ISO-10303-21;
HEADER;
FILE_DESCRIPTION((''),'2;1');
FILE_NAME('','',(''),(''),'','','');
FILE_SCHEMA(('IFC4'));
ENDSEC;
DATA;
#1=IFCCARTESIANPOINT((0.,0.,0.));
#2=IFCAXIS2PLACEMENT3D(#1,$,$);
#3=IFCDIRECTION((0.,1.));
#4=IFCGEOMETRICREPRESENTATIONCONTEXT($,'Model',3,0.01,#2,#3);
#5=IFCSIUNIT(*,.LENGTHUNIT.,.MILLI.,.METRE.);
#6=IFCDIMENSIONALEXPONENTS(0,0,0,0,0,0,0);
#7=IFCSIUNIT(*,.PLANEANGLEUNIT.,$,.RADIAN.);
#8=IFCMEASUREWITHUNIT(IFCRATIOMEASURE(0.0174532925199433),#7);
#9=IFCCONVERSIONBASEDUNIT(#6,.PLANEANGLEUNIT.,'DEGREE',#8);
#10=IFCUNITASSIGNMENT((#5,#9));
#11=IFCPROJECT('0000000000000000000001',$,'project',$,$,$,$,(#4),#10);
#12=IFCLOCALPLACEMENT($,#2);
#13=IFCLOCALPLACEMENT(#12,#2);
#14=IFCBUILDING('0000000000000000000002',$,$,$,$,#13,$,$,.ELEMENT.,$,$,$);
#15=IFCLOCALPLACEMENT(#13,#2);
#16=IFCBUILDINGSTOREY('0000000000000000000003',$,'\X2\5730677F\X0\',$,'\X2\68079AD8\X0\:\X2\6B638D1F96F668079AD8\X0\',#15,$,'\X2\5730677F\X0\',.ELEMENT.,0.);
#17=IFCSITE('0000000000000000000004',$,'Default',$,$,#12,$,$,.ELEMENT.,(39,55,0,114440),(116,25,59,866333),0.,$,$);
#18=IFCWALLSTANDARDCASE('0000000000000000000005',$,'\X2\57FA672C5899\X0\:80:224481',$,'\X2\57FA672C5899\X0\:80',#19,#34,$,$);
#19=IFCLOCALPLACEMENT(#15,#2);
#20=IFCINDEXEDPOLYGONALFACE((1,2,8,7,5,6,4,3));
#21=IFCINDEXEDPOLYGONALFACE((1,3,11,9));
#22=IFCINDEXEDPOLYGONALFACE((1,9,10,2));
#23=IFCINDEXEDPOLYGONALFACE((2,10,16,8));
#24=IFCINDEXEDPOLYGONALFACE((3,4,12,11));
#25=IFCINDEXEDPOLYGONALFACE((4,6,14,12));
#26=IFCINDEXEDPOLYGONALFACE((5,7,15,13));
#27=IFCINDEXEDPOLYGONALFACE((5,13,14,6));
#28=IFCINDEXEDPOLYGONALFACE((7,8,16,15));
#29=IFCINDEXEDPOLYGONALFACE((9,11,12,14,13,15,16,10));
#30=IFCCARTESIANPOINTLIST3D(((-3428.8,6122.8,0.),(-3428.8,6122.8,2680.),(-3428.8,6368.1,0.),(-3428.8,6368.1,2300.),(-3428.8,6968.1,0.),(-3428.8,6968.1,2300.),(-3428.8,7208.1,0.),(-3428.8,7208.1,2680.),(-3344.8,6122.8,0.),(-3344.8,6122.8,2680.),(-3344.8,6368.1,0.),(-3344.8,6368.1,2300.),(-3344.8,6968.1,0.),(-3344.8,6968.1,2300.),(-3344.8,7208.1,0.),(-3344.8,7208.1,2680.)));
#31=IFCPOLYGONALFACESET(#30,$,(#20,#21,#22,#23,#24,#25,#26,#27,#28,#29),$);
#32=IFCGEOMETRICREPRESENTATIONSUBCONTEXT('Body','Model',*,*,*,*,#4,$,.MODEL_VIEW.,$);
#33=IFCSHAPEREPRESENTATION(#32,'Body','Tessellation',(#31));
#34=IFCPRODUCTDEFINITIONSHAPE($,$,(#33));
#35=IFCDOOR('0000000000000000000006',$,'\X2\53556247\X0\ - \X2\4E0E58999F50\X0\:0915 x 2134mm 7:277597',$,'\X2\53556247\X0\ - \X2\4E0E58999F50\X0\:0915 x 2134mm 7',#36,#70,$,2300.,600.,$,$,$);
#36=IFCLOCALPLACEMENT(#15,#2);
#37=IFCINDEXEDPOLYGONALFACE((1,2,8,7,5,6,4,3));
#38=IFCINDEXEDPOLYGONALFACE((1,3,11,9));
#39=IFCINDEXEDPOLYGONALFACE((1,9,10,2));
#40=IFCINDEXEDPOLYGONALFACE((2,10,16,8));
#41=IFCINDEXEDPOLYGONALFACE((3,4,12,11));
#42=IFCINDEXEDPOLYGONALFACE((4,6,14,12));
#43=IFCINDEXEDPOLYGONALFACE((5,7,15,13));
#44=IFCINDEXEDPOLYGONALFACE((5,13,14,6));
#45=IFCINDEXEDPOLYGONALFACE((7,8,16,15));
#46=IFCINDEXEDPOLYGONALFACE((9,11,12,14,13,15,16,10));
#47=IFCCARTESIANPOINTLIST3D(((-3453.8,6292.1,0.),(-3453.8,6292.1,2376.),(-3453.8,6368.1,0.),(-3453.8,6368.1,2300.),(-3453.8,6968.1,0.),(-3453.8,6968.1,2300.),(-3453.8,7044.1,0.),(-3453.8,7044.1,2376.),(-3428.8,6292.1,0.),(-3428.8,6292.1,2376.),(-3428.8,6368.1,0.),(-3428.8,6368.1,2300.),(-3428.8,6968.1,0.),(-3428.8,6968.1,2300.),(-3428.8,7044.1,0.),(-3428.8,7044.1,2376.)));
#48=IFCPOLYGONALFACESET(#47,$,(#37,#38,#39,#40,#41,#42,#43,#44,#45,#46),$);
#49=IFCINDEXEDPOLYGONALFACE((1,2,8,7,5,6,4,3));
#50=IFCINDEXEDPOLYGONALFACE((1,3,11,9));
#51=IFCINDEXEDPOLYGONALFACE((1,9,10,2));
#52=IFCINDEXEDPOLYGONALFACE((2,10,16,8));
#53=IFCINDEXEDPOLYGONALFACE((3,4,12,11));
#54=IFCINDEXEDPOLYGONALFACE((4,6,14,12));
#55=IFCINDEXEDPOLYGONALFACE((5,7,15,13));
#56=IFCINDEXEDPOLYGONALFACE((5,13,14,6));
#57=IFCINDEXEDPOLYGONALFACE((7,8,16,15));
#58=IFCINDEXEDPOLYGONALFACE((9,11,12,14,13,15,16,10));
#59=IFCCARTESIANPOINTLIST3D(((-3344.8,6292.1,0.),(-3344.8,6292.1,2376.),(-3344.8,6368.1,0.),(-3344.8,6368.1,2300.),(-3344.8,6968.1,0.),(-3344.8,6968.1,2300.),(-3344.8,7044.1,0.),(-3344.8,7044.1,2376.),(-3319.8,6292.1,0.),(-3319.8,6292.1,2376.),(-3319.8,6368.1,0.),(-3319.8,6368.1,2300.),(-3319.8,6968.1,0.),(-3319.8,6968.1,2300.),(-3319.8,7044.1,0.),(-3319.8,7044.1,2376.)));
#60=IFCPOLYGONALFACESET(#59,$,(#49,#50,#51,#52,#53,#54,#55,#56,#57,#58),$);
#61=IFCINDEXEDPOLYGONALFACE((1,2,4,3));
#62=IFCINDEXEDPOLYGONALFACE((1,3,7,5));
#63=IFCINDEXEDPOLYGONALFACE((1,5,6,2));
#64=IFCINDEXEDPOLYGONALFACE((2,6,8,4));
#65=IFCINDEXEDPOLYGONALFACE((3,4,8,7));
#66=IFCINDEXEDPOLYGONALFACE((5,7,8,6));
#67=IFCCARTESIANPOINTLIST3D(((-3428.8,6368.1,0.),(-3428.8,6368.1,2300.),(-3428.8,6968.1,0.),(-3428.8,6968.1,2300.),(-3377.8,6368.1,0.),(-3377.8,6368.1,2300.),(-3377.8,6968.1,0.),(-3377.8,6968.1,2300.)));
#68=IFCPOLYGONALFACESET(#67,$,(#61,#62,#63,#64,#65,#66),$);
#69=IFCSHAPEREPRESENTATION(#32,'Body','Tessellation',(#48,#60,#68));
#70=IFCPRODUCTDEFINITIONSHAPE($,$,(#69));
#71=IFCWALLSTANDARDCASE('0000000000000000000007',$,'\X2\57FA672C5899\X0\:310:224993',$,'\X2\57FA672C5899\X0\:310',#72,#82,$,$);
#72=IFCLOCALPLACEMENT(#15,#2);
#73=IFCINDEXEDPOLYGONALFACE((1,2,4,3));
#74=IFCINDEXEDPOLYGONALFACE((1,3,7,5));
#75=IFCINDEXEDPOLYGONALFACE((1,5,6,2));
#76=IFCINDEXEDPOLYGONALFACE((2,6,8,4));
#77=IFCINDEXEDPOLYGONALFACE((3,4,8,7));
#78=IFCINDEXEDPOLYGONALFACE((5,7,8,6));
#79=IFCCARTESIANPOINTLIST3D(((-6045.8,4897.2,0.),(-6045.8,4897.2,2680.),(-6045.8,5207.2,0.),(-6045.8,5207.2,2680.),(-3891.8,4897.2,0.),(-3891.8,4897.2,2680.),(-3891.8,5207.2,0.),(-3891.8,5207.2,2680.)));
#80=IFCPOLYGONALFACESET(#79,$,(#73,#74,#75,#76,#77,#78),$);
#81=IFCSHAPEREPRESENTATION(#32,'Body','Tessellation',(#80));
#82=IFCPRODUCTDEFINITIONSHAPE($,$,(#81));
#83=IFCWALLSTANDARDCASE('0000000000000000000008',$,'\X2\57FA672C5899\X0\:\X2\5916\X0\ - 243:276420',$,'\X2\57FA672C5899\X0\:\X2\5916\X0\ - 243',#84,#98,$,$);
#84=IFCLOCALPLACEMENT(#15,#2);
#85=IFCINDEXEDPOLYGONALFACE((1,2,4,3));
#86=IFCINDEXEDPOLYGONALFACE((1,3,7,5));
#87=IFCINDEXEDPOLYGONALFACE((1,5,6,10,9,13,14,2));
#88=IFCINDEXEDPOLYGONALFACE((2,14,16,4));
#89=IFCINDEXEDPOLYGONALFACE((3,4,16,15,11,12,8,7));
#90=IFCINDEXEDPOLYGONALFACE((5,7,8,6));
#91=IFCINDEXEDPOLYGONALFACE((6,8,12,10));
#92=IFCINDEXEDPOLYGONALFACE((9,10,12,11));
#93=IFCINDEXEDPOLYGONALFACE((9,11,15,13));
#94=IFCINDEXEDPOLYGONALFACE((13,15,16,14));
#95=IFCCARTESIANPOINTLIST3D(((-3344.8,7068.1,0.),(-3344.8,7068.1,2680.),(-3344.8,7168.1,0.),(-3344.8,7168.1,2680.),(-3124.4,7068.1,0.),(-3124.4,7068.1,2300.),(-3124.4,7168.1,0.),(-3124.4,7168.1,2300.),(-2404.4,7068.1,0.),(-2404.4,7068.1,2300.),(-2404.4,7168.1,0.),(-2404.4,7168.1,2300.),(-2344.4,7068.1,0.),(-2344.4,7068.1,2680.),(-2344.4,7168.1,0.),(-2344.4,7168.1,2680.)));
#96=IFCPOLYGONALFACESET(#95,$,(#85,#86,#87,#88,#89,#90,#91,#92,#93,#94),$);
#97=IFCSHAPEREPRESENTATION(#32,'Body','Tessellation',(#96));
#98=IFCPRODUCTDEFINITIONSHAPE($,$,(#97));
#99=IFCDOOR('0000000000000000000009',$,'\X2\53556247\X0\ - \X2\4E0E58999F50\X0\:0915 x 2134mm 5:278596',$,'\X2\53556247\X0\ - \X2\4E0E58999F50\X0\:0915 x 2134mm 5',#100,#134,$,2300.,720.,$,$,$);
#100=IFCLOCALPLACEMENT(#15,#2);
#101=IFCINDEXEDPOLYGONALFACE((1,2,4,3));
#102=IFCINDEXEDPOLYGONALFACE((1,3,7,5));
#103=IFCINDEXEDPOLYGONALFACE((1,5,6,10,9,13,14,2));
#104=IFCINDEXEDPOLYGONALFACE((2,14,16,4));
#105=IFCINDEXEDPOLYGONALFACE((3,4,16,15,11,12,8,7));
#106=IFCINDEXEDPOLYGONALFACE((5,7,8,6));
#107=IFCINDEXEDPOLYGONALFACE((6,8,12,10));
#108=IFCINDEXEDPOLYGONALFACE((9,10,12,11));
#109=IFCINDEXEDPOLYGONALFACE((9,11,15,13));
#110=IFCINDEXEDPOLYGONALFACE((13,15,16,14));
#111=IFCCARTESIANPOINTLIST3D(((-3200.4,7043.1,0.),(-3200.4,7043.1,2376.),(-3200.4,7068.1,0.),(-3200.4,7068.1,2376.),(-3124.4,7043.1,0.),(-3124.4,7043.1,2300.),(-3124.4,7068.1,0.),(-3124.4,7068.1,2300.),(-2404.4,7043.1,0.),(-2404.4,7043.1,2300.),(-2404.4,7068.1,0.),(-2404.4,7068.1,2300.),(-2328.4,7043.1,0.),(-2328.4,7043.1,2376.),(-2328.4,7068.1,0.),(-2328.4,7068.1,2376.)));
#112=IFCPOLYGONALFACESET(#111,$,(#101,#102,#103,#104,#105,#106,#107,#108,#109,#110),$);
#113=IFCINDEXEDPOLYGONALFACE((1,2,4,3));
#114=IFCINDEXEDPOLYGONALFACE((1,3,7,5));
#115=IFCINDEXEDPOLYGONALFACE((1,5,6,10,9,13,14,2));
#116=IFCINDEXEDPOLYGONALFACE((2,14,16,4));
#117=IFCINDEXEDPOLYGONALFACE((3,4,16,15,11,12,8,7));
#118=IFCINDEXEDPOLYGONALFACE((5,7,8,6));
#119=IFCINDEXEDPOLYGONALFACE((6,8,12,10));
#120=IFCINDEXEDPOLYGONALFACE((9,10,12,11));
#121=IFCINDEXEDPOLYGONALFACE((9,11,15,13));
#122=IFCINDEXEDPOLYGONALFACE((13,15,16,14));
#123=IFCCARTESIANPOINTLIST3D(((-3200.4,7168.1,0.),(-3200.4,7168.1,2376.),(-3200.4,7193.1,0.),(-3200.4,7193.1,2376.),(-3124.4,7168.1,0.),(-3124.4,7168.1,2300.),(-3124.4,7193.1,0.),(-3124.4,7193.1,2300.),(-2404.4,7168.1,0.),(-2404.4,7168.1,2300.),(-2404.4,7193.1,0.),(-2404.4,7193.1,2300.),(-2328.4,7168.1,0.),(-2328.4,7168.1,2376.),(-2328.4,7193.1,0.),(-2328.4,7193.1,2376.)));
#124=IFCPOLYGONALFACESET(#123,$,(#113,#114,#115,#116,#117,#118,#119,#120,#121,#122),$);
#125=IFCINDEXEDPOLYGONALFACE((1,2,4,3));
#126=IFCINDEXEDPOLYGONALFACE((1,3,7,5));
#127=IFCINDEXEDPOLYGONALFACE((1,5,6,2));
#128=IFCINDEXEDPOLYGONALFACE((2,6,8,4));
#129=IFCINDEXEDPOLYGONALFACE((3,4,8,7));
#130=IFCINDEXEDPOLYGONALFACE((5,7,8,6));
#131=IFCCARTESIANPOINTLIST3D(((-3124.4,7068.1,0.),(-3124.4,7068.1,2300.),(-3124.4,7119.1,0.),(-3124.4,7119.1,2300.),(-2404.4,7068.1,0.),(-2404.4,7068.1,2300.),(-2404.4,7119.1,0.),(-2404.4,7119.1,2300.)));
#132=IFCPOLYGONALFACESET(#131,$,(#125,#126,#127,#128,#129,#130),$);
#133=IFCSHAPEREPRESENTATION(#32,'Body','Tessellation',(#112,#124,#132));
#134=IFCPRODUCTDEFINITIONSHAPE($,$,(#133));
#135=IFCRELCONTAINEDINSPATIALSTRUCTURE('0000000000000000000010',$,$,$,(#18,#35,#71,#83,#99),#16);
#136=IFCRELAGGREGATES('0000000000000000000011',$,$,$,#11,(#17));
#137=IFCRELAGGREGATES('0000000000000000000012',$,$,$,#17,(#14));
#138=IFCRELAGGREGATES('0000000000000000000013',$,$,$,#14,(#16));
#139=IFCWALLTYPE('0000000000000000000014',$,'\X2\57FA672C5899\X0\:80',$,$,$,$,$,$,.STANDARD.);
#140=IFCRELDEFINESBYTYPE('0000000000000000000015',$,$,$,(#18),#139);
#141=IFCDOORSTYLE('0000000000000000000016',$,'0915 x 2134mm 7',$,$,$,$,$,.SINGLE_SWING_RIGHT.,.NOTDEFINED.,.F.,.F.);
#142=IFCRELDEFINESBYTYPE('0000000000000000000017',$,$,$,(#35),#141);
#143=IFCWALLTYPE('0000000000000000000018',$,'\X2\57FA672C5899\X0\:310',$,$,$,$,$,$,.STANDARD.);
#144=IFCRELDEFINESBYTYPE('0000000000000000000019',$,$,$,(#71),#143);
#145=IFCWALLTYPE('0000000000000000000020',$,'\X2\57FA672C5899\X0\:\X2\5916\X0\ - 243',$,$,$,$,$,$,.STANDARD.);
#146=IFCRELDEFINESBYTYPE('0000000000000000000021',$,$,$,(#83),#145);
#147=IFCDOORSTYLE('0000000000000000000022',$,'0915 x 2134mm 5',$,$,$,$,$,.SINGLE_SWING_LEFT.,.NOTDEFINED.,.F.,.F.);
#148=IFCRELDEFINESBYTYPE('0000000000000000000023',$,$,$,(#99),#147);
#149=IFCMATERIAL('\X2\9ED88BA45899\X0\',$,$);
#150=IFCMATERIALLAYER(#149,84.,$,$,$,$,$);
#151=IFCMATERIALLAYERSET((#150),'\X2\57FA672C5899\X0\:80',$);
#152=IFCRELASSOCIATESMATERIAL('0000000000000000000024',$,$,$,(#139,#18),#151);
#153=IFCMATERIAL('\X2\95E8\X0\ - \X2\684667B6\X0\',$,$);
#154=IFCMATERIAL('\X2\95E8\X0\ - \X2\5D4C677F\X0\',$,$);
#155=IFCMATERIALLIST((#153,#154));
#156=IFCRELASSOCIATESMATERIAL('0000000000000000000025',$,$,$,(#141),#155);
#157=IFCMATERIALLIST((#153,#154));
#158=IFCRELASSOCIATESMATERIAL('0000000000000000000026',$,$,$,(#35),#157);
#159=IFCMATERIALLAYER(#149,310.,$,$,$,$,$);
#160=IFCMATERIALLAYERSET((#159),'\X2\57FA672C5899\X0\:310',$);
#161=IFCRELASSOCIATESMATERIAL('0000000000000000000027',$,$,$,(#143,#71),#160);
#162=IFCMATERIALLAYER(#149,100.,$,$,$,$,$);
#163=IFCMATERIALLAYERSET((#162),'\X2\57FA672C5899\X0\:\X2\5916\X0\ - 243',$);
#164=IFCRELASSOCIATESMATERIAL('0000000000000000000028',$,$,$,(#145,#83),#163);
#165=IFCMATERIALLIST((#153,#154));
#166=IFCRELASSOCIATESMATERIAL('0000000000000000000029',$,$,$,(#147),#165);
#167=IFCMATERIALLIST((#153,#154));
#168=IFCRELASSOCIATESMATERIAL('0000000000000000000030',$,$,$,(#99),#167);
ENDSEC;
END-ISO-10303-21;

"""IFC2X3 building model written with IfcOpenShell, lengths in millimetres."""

from ifc_helpers import new_model, entity, si_unit, converted_unit, direction, frame, frame_2d, origin, origin_2d_with_axis, place, context, subcontext, project, spatial, polyline, rectangle, outline, extrude, source, transform, mapped, material, material_list, layer, layer_set, layer_usage, type_object, type_shapes, element, fill, save


model = new_model("IFC2X3")

# Units and contexts
model_context = context("Model", 3, precision=0.01, world=origin(), true_north=direction((0.0, 1.0)))
body_context = subcontext(model_context, "Body", "Model", "MODEL_VIEW")
ifc_project = project(units=[si_unit("LENGTHUNIT", "METRE", prefix="MILLI"), converted_unit("PLANEANGLEUNIT", "DEGREE", entity("IfcRatioMeasure", 0.0174532925199433), si_unit("PLANEANGLEUNIT", "RADIAN"), dimensions=[0, 0, 0, 0, 0, 0, 0])], contexts=[model_context])

# Site, building, storey
site_placement = place(None, origin())
site = spatial("IfcSite", under=ifc_project, at=site_placement, Name="Default", CompositionType="ELEMENT", RefLatitude=(39, 55, 0, 114440), RefLongitude=(116, 25, 59, 866333), RefElevation=0.0)
building_placement = place(site_placement, origin())
building = spatial("IfcBuilding", under=site, at=building_placement, CompositionType="ELEMENT")
storey_placement = place(building_placement, origin())
storey = spatial("IfcBuildingStorey", under=building, at=storey_placement, Name="地板", ObjectType="标高:正负零标高", LongName="地板", CompositionType="ELEMENT", Elevation=0.0)

# Shared definitions
ifc_material_1 = material(Name="默认墙")

# Wall, opening, door
ifc_layer_1 = layer(ifc_material_1, 84.0)
ifc_layer_set_1 = layer_set([ifc_layer_1], Name="基本墙:80")
ifc_layer_usage_1 = layer_usage(ifc_layer_set_1, "AXIS2", "NEGATIVE", 42.0)
wall_type_1 = type_object("IfcWallType", Name="基本墙:80", PredefinedType="STANDARD", material=ifc_layer_set_1)
wall_1_placement = place(storey_placement, frame((-3386.8, 7208.1, 0.0), z_axis=(0.0, 0.0, 1.0), x_axis=(0.0, -1.0, 0.0)))
wall_1 = element("IfcWallStandardCase", 1, at=wall_1_placement, inside=storey, type_object=wall_type_1, material=ifc_layer_usage_1, Name="基本墙:80:224481", ObjectType="基本墙:80", context=body_context, shape_type="SweptSolid", body=[
    extrude(rectangle(XDim=1085.3, YDim=84.0, at=frame_2d((542.6, 0.0), x_axis=(-1.0, 0.0))), origin(), (0.0, 0.0, 1.0), 2680.0),
])
opening_1_placement = place(wall_1_placement, frame((840.0, 42.0, 0.0)))
opening_1 = element("IfcOpeningElement", 2, at=opening_1_placement, cuts=wall_1, ObjectType="Opening", context=body_context, shape_type="SweptSolid", body=[
    extrude(rectangle(XDim=600.0, YDim=2300.0, at=frame_2d((1150.0, 300.0), x_axis=(0.0, 1.0))), frame((0.0, 0.0, 0.0), z_axis=(0.0, -1.0, 0.0), x_axis=(0.0, 0.0, 1.0)), (0.0, 0.0, 1.0), 84.0),
])
ifc_material_2 = material(Name="门 - 框架")
ifc_material_3 = material(Name="门 - 嵌板")
ifc_material_list_1 = material_list([ifc_material_2, ifc_material_3])
ifc_material_list_2 = material_list([ifc_material_2, ifc_material_3])
door_style_1 = type_object("IfcDoorStyle", Name="0915 x 2134mm 7", ConstructionType="NOTDEFINED", OperationType="SINGLE_SWING_RIGHT", ParameterTakesPrecedence=False, Sizeable=False, material=ifc_material_list_2)
shared_shape_1 = source(origin(), body_context, "Body", "SweptSolid", [
    extrude(outline(polyline([(-376.0, -1207.0), (376.0, -1207.0), (376.0, 1169.0), (300.0, 1169.0), (300.0, -1131.0), (-300.0, -1131.0), (-300.0, 1169.0), (-376.0, 1169.0), (-376.0, -1207.0)])), frame((300.0, 84.0, 1169.0), z_axis=(0.0, 1.0, 0.0), x_axis=(1.0, 0.0, 0.0)), (0.0, 0.0, 1.0), 25.0),
    extrude(outline(polyline([(-1207.0, -376.0), (1169.0, -376.0), (1169.0, -300.0), (-1131.0, -300.0), (-1131.0, 300.0), (1169.0, 300.0), (1169.0, 376.0), (-1207.0, 376.0), (-1207.0, -376.0)])), frame((300.0, -25.0, 1169.0), z_axis=(0.0, 1.0, 0.0), x_axis=(0.0, 0.0, -1.0)), (0.0, 0.0, 1.0), 25.0),
    extrude(rectangle(XDim=51.0, YDim=600.0, at=origin_2d_with_axis()), frame((300.0, 58.5, 0.0), z_axis=(0.0, 0.0, 1.0), x_axis=(0.0, 1.0, 0.0)), (0.0, 0.0, 1.0), 2300.0),
])
type_shapes(door_style_1, [shared_shape_1])
door_1_placement = place(opening_1_placement, frame((0.0, 0.0, 0.0), z_axis=(0.0, 0.0, 1.0), x_axis=(-1.0, 0.0, 0.0)))
door_1 = element("IfcDoor", 3, at=door_1_placement, inside=storey, type_object=door_style_1, material=ifc_material_list_1, Name="单扇 - 与墙齐:0915 x 2134mm 7:277597", ObjectType="单扇 - 与墙齐:0915 x 2134mm 7", OverallHeight=2300.0, OverallWidth=600.0, context=body_context, shape_type="MappedRepresentation", body=[
    mapped(shared_shape_1, transform((0.0, 0.0, 0.0), scale=1.0)),
])
fill(opening_1, door_1)

# Wall
ifc_layer_2 = layer(ifc_material_1, 310.0)
ifc_layer_set_2 = layer_set([ifc_layer_2], Name="基本墙:310")
ifc_layer_usage_2 = layer_usage(ifc_layer_set_2, "AXIS2", "NEGATIVE", 155.0)
wall_type_2 = type_object("IfcWallType", Name="基本墙:310", PredefinedType="STANDARD", material=ifc_layer_set_2)
wall_2_placement = place(storey_placement, frame((-6045.8, 5052.2, 0.0)))
element("IfcWallStandardCase", 4, at=wall_2_placement, inside=storey, type_object=wall_type_2, material=ifc_layer_usage_2, Name="基本墙:310:224993", ObjectType="基本墙:310", context=body_context, shape_type="SweptSolid", body=[
    extrude(rectangle(XDim=2154.0, YDim=310.0, at=frame_2d((1077.0, 0.0), x_axis=(-1.0, 0.0))), origin(), (0.0, 0.0, 1.0), 2680.0),
])

# Wall, opening, door
ifc_layer_3 = layer(ifc_material_1, 100.0)
ifc_layer_set_3 = layer_set([ifc_layer_3], Name="基本墙:外 - 243")
ifc_layer_usage_3 = layer_usage(ifc_layer_set_3, "AXIS2", "NEGATIVE", 50.0)
wall_type_3 = type_object("IfcWallType", Name="基本墙:外 - 243", PredefinedType="STANDARD", material=ifc_layer_set_3)
wall_3_placement = place(storey_placement, frame((-3344.8, 7118.1, 0.0)))
wall_3 = element("IfcWallStandardCase", 5, at=wall_3_placement, inside=storey, type_object=wall_type_3, material=ifc_layer_usage_3, Name="基本墙:外 - 243:276420", ObjectType="基本墙:外 - 243", context=body_context, shape_type="SweptSolid", body=[
    extrude(rectangle(XDim=1000.3, YDim=100.0, at=frame_2d((500.2, 0.0), x_axis=(-1.0, 0.0))), origin(), (0.0, 0.0, 1.0), 2680.0),
])
opening_2_placement = place(wall_3_placement, frame((940.3, 50.0, 0.0)))
opening_2 = element("IfcOpeningElement", 6, at=opening_2_placement, cuts=wall_3, ObjectType="Opening", context=body_context, shape_type="SweptSolid", body=[
    extrude(rectangle(XDim=720.0, YDim=2300.0, at=frame_2d((1150.0, 360.0), x_axis=(0.0, -1.0))), frame((0.0, 0.0, 0.0), z_axis=(0.0, -1.0, 0.0), x_axis=(0.0, 0.0, 1.0)), (0.0, 0.0, 1.0), 100.0),
])
ifc_material_list_3 = material_list([ifc_material_2, ifc_material_3])
ifc_material_list_4 = material_list([ifc_material_2, ifc_material_3])
door_style_2 = type_object("IfcDoorStyle", Name="0915 x 2134mm 5", ConstructionType="NOTDEFINED", OperationType="SINGLE_SWING_LEFT", ParameterTakesPrecedence=False, Sizeable=False, material=ifc_material_list_4)
shared_shape_2 = source(origin(), body_context, "Body", "SweptSolid", [
    extrude(outline(polyline([(-436.0, -1207.0), (436.0, -1207.0), (436.0, 1169.0), (360.0, 1169.0), (360.0, -1131.0), (-360.0, -1131.0), (-360.0, 1169.0), (-436.0, 1169.0), (-436.0, -1207.0)])), frame((360.0, 125.0, 1169.0), z_axis=(0.0, -1.0, 0.0), x_axis=(-1.0, 0.0, 0.0)), (0.0, 0.0, 1.0), 25.0),
    extrude(outline(polyline([(-1207.0, -436.0), (1169.0, -436.0), (1169.0, -360.0), (-1131.0, -360.0), (-1131.0, 360.0), (1169.0, 360.0), (1169.0, 436.0), (-1207.0, 436.0), (-1207.0, -436.0)])), frame((360.0, 0.0, 1169.0), z_axis=(0.0, -1.0, 0.0), x_axis=(0.0, 0.0, -1.0)), (0.0, 0.0, 1.0), 25.0),
    extrude(rectangle(XDim=720.0, YDim=51.0, at=origin_2d_with_axis()), frame((360.0, 74.5, 0.0)), (0.0, 0.0, 1.0), 2300.0),
])
type_shapes(door_style_2, [shared_shape_2])
door_2_placement = place(opening_2_placement, frame((0.0, 0.0, 0.0), z_axis=(0.0, 0.0, 1.0), x_axis=(-1.0, 0.0, 0.0)))
door_2 = element("IfcDoor", 7, at=door_2_placement, inside=storey, type_object=door_style_2, material=ifc_material_list_3, Name="单扇 - 与墙齐:0915 x 2134mm 5:278596", ObjectType="单扇 - 与墙齐:0915 x 2134mm 5", OverallHeight=2300.0, OverallWidth=720.0, context=body_context, shape_type="MappedRepresentation", body=[
    mapped(shared_shape_2, transform((0.0, 0.0, 0.0), scale=1.0)),
])
fill(opening_2, door_2)

save(model, "model.ifc")
